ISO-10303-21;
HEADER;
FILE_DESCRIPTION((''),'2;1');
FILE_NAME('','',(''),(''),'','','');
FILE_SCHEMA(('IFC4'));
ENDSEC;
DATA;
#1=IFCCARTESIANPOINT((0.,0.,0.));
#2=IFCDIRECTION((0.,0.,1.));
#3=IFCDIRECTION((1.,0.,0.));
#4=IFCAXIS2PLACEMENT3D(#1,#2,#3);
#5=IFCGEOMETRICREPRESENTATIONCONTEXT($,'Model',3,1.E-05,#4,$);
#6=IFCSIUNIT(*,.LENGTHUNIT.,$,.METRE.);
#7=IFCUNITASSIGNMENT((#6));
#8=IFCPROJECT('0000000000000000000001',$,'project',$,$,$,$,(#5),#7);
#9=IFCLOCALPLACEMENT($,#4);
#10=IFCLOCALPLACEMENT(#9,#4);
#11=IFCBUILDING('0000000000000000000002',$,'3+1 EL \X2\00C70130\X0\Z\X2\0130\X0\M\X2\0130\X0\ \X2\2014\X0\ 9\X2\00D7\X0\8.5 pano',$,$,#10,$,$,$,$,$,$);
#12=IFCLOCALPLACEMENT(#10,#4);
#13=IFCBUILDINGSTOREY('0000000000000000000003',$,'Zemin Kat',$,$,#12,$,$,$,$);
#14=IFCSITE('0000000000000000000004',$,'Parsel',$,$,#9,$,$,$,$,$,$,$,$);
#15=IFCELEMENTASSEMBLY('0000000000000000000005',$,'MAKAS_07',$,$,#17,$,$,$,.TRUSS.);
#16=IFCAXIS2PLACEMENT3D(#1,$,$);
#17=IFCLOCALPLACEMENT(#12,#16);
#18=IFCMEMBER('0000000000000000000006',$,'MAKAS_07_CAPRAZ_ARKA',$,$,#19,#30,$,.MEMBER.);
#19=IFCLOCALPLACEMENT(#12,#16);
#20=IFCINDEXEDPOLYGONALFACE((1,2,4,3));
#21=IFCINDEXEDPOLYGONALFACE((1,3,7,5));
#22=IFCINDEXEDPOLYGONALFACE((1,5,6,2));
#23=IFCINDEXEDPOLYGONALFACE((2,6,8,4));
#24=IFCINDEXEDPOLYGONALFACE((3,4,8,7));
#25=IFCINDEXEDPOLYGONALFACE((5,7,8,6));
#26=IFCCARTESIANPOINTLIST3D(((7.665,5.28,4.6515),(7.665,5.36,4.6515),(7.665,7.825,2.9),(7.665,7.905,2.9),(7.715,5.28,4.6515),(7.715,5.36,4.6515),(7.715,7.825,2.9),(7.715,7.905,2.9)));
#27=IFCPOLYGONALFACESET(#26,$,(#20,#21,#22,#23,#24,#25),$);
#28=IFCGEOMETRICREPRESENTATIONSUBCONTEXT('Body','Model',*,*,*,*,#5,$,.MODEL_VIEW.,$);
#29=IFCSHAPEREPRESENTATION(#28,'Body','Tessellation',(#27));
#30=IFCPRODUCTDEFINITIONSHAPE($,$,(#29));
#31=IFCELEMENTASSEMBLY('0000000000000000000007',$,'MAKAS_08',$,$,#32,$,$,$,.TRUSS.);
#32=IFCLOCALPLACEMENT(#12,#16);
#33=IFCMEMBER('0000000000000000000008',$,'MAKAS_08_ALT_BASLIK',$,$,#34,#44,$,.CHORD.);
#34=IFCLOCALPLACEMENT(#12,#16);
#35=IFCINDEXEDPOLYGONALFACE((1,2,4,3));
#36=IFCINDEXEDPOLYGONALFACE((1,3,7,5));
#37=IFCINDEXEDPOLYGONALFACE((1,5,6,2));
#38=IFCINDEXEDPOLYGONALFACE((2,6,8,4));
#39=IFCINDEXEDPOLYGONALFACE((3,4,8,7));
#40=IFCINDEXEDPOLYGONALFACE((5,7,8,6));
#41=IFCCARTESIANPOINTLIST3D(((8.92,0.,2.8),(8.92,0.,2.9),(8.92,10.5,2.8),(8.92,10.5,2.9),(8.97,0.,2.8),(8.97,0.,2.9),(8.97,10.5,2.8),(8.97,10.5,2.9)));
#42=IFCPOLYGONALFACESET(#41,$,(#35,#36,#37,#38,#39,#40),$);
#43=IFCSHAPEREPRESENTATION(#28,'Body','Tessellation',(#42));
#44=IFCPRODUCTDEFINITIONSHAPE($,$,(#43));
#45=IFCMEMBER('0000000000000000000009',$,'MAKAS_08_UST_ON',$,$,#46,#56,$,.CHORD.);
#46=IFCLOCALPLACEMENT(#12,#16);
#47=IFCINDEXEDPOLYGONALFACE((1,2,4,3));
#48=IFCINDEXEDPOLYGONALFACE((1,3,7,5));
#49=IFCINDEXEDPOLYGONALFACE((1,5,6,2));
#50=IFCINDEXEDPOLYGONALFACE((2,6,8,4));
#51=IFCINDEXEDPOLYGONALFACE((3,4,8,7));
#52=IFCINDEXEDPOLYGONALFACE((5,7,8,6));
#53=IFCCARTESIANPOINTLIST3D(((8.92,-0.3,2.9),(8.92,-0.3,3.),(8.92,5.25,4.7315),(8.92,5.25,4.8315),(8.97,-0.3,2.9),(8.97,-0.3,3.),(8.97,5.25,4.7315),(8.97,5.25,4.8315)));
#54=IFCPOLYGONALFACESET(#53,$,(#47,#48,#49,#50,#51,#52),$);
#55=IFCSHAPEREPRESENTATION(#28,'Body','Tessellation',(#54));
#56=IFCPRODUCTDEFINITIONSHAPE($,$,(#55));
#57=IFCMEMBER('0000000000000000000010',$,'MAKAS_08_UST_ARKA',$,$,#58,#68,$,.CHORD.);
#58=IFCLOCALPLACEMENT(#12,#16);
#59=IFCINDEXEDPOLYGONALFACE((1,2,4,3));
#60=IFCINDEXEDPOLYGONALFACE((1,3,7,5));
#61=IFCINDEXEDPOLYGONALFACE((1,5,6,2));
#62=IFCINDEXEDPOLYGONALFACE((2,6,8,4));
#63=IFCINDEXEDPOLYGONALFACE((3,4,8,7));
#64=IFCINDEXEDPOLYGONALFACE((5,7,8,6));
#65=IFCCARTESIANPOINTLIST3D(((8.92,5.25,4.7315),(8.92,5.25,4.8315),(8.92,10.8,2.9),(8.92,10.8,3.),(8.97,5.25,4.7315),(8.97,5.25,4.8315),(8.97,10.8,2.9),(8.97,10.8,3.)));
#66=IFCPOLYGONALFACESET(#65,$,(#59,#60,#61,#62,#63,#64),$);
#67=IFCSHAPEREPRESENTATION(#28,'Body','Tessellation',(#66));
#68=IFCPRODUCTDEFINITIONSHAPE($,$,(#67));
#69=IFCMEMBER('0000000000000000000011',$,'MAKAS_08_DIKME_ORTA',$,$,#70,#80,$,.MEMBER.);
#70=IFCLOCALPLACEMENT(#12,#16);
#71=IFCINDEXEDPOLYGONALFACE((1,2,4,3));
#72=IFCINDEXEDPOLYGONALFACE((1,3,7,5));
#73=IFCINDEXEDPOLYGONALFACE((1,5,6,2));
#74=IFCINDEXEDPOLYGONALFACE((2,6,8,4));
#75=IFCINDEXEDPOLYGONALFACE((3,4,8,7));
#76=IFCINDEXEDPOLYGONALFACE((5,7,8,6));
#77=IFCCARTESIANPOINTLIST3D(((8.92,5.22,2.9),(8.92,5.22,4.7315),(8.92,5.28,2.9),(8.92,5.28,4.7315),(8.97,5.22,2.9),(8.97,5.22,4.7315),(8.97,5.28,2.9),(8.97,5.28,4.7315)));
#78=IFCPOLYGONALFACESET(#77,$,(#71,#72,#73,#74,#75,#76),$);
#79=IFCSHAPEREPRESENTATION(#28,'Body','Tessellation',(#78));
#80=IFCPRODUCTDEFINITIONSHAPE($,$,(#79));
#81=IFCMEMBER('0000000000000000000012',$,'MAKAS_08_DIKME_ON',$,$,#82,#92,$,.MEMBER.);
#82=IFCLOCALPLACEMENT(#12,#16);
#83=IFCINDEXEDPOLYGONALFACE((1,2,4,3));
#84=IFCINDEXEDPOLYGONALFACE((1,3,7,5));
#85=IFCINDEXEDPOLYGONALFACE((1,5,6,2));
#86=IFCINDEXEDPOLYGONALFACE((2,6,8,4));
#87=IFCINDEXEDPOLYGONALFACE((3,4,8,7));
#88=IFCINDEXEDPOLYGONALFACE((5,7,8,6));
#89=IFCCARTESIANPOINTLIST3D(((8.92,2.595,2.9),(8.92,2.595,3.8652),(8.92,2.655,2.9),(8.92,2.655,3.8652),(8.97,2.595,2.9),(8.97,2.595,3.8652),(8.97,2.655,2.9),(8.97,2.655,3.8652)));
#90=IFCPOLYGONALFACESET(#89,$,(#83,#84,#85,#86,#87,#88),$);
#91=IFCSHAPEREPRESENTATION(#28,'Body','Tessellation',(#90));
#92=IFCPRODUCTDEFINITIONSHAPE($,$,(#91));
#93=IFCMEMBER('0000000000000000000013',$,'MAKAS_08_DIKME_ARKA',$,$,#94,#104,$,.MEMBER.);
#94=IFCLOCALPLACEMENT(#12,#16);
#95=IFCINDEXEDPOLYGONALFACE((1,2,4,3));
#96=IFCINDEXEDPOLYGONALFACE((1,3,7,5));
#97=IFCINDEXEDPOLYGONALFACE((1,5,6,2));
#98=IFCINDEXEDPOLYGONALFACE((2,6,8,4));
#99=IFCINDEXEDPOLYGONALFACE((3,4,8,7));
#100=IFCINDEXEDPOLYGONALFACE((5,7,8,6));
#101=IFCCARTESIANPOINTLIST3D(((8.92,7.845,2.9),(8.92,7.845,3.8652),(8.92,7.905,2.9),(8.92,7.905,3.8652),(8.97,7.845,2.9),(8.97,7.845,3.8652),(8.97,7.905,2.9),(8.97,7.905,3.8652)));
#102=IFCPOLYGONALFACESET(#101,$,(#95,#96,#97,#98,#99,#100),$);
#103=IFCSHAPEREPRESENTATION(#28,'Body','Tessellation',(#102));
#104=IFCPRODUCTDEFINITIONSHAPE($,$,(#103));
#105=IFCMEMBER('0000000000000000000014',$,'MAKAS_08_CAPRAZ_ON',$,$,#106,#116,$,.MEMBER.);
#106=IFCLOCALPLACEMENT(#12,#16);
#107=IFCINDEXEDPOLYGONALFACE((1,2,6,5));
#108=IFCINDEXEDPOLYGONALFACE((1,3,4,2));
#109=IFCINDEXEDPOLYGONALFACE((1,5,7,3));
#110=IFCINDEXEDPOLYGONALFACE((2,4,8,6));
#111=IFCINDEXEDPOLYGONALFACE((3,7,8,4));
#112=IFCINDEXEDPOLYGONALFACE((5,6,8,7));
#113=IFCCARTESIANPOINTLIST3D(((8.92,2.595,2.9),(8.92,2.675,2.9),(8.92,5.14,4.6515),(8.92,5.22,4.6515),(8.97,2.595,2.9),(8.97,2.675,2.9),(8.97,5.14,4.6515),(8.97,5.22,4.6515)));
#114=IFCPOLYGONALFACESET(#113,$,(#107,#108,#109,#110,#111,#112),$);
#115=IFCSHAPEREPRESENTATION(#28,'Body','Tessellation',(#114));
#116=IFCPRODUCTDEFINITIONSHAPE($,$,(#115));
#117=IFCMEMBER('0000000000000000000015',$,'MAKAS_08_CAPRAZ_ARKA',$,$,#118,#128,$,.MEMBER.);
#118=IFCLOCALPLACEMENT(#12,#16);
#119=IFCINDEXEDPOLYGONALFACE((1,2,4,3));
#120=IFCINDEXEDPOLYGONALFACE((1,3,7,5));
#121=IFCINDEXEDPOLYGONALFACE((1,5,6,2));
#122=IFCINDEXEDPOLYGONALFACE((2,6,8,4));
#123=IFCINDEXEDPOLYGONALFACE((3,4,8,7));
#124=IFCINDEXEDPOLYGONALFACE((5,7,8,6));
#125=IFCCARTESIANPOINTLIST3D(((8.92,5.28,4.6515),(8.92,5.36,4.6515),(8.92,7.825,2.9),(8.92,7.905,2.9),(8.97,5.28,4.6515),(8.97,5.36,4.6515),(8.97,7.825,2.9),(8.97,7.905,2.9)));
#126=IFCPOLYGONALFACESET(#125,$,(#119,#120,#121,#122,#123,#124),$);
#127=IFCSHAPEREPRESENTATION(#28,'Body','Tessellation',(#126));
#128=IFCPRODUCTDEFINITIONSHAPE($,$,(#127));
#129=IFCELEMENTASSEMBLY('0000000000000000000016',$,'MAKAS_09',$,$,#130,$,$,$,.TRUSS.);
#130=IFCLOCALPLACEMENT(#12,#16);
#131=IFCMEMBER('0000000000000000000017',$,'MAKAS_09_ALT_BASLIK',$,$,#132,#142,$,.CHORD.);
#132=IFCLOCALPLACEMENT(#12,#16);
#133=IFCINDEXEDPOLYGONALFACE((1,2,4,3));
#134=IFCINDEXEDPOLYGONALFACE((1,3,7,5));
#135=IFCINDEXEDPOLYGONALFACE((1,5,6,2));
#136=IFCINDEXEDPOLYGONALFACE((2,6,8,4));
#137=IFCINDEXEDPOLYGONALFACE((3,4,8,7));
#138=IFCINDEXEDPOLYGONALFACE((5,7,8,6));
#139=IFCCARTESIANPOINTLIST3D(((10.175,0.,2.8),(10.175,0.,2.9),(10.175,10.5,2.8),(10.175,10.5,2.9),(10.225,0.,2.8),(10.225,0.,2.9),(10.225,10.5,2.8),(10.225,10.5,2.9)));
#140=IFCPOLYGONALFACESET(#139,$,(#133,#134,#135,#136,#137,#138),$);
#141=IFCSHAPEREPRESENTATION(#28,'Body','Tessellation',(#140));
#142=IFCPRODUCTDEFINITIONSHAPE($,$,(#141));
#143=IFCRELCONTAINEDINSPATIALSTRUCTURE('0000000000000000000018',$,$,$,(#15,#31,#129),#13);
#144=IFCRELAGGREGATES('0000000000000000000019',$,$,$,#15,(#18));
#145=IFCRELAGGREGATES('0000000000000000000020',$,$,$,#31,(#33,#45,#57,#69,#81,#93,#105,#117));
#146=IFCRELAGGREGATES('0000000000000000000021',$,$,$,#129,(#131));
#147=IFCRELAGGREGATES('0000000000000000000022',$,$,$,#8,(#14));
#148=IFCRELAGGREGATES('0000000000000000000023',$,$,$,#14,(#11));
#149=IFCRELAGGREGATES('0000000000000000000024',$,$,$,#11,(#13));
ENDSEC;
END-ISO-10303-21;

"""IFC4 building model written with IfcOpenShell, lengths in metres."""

from ifc_helpers import new_model, si_unit, frame, origin_with_axes, place, context, subcontext, project, spatial, line, indexed_curve, outline, extrude, element, aggregate, save


model = new_model("IFC4")

# Units and contexts
model_context = context("Model", 3, precision=1e-05, world=origin_with_axes())
body_context = subcontext(model_context, "Body", "Model", "MODEL_VIEW")
ifc_project = project(units=[si_unit("LENGTHUNIT", "METRE")], contexts=[model_context])

# Site, building, storey
site_placement = place(None, origin_with_axes())
site = spatial("IfcSite", under=ifc_project, at=site_placement, Name="Parsel")
building_placement = place(site_placement, origin_with_axes())
building = spatial("IfcBuilding", under=site, at=building_placement, Name="3+1 EL ÇİZİMİ — 9×8.5 pano")
storey_placement = place(building_placement, origin_with_axes())
storey = spatial("IfcBuildingStorey", under=building, at=storey_placement, Name="Zemin Kat")

# Element assemblies, members
assembly_1_placement = place(storey_placement, origin_with_axes())
assembly_1 = element("IfcElementAssembly", 1, at=assembly_1_placement, inside=storey, Name="MAKAS_07", PredefinedType="TRUSS")
member_1_placement = place(assembly_1_placement, origin_with_axes())
member_1 = element("IfcMember", 2, at=member_1_placement, Name="MAKAS_07_CAPRAZ_ARKA", PredefinedType="MEMBER", context=body_context, shape_type="SweptSolid", body=[
    extrude(outline(indexed_curve([(7.825, 2.9), (7.905, 2.9), (5.36, 4.6515), (5.28, 4.6515)], segments=[line(1, 2, 3, 4, 1)])), frame((7.665, 0.0, 0.0), z_axis=(1.0, 0.0, 0.0), x_axis=(0.0, 1.0, 0.0)), (0.0, 0.0, 1.0), 0.05),
])
aggregate(assembly_1, [member_1])
assembly_2_placement = place(storey_placement, origin_with_axes())
assembly_2 = element("IfcElementAssembly", 3, at=assembly_2_placement, inside=storey, Name="MAKAS_08", PredefinedType="TRUSS")
member_2_placement = place(assembly_2_placement, origin_with_axes())
member_2 = element("IfcMember", 4, at=member_2_placement, Name="MAKAS_08_ALT_BASLIK", PredefinedType="CHORD", context=body_context, shape_type="SweptSolid", body=[
    extrude(outline(indexed_curve([(0.0, 2.8), (10.5, 2.8), (10.5, 2.9), (0.0, 2.9)], segments=[line(1, 2, 3, 4, 1)])), frame((8.92, 0.0, 0.0), z_axis=(1.0, 0.0, 0.0), x_axis=(0.0, 1.0, 0.0)), (0.0, 0.0, 1.0), 0.05),
])
member_3_placement = place(assembly_2_placement, origin_with_axes())
member_3 = element("IfcMember", 5, at=member_3_placement, Name="MAKAS_08_UST_ON", PredefinedType="CHORD", context=body_context, shape_type="SweptSolid", body=[
    extrude(outline(indexed_curve([(-0.3, 2.9), (5.25, 4.7315), (5.25, 4.8315), (-0.3, 3.0)], segments=[line(1, 2, 3, 4, 1)])), frame((8.92, 0.0, 0.0), z_axis=(1.0, 0.0, 0.0), x_axis=(0.0, 1.0, 0.0)), (0.0, 0.0, 1.0), 0.05),
])
member_4_placement = place(assembly_2_placement, origin_with_axes())
member_4 = element("IfcMember", 6, at=member_4_placement, Name="MAKAS_08_UST_ARKA", PredefinedType="CHORD", context=body_context, shape_type="SweptSolid", body=[
    extrude(outline(indexed_curve([(5.25, 4.7315), (10.8, 2.9), (10.8, 3.0), (5.25, 4.8315)], segments=[line(1, 2, 3, 4, 1)])), frame((8.92, 0.0, 0.0), z_axis=(1.0, 0.0, 0.0), x_axis=(0.0, 1.0, 0.0)), (0.0, 0.0, 1.0), 0.05),
])
member_5_placement = place(assembly_2_placement, origin_with_axes())
member_5 = element("IfcMember", 7, at=member_5_placement, Name="MAKAS_08_DIKME_ORTA", PredefinedType="MEMBER", context=body_context, shape_type="SweptSolid", body=[
    extrude(outline(indexed_curve([(5.22, 2.9), (5.28, 2.9), (5.28, 4.7315), (5.22, 4.7315)], segments=[line(1, 2, 3, 4, 1)])), frame((8.92, 0.0, 0.0), z_axis=(1.0, 0.0, 0.0), x_axis=(0.0, 1.0, 0.0)), (0.0, 0.0, 1.0), 0.05),
])
member_6_placement = place(assembly_2_placement, origin_with_axes())
member_6 = element("IfcMember", 8, at=member_6_placement, Name="MAKAS_08_DIKME_ON", PredefinedType="MEMBER", context=body_context, shape_type="SweptSolid", body=[
    extrude(outline(indexed_curve([(2.595, 2.9), (2.655, 2.9), (2.655, 3.8653), (2.595, 3.8653)], segments=[line(1, 2, 3, 4, 1)])), frame((8.92, 0.0, 0.0), z_axis=(1.0, 0.0, 0.0), x_axis=(0.0, 1.0, 0.0)), (0.0, 0.0, 1.0), 0.05),
])
member_7_placement = place(assembly_2_placement, origin_with_axes())
member_7 = element("IfcMember", 9, at=member_7_placement, Name="MAKAS_08_DIKME_ARKA", PredefinedType="MEMBER", context=body_context, shape_type="SweptSolid", body=[
    extrude(outline(indexed_curve([(7.845, 2.9), (7.905, 2.9), (7.905, 3.8653), (7.845, 3.8653)], segments=[line(1, 2, 3, 4, 1)])), frame((8.92, 0.0, 0.0), z_axis=(1.0, 0.0, 0.0), x_axis=(0.0, 1.0, 0.0)), (0.0, 0.0, 1.0), 0.05),
])
member_8_placement = place(assembly_2_placement, origin_with_axes())
member_8 = element("IfcMember", 10, at=member_8_placement, Name="MAKAS_08_CAPRAZ_ON", PredefinedType="MEMBER", context=body_context, shape_type="SweptSolid", body=[
    extrude(outline(indexed_curve([(2.595, 2.9), (2.675, 2.9), (5.22, 4.6515), (5.14, 4.6515)], segments=[line(1, 2, 3, 4, 1)])), frame((8.92, 0.0, 0.0), z_axis=(1.0, 0.0, 0.0), x_axis=(0.0, 1.0, 0.0)), (0.0, 0.0, 1.0), 0.05),
])
member_9_placement = place(assembly_2_placement, origin_with_axes())
member_9 = element("IfcMember", 11, at=member_9_placement, Name="MAKAS_08_CAPRAZ_ARKA", PredefinedType="MEMBER", context=body_context, shape_type="SweptSolid", body=[
    extrude(outline(indexed_curve([(7.825, 2.9), (7.905, 2.9), (5.36, 4.6515), (5.28, 4.6515)], segments=[line(1, 2, 3, 4, 1)])), frame((8.92, 0.0, 0.0), z_axis=(1.0, 0.0, 0.0), x_axis=(0.0, 1.0, 0.0)), (0.0, 0.0, 1.0), 0.05),
])
aggregate(assembly_2, [member_2, member_3, member_4, member_5, member_6, member_7, member_8, member_9])

# Element assembly, member
assembly_3_placement = place(storey_placement, origin_with_axes())
assembly_3 = element("IfcElementAssembly", 12, at=assembly_3_placement, inside=storey, Name="MAKAS_09", PredefinedType="TRUSS")
member_10_placement = place(assembly_3_placement, origin_with_axes())
member_10 = element("IfcMember", 13, at=member_10_placement, Name="MAKAS_09_ALT_BASLIK", PredefinedType="CHORD", context=body_context, shape_type="SweptSolid", body=[
    extrude(outline(indexed_curve([(0.0, 2.8), (10.5, 2.8), (10.5, 2.9), (0.0, 2.9)], segments=[line(1, 2, 3, 4, 1)])), frame((10.175, 0.0, 0.0), z_axis=(1.0, 0.0, 0.0), x_axis=(0.0, 1.0, 0.0)), (0.0, 0.0, 1.0), 0.05),
])
aggregate(assembly_3, [member_10])

save(model, "model.ifc")
